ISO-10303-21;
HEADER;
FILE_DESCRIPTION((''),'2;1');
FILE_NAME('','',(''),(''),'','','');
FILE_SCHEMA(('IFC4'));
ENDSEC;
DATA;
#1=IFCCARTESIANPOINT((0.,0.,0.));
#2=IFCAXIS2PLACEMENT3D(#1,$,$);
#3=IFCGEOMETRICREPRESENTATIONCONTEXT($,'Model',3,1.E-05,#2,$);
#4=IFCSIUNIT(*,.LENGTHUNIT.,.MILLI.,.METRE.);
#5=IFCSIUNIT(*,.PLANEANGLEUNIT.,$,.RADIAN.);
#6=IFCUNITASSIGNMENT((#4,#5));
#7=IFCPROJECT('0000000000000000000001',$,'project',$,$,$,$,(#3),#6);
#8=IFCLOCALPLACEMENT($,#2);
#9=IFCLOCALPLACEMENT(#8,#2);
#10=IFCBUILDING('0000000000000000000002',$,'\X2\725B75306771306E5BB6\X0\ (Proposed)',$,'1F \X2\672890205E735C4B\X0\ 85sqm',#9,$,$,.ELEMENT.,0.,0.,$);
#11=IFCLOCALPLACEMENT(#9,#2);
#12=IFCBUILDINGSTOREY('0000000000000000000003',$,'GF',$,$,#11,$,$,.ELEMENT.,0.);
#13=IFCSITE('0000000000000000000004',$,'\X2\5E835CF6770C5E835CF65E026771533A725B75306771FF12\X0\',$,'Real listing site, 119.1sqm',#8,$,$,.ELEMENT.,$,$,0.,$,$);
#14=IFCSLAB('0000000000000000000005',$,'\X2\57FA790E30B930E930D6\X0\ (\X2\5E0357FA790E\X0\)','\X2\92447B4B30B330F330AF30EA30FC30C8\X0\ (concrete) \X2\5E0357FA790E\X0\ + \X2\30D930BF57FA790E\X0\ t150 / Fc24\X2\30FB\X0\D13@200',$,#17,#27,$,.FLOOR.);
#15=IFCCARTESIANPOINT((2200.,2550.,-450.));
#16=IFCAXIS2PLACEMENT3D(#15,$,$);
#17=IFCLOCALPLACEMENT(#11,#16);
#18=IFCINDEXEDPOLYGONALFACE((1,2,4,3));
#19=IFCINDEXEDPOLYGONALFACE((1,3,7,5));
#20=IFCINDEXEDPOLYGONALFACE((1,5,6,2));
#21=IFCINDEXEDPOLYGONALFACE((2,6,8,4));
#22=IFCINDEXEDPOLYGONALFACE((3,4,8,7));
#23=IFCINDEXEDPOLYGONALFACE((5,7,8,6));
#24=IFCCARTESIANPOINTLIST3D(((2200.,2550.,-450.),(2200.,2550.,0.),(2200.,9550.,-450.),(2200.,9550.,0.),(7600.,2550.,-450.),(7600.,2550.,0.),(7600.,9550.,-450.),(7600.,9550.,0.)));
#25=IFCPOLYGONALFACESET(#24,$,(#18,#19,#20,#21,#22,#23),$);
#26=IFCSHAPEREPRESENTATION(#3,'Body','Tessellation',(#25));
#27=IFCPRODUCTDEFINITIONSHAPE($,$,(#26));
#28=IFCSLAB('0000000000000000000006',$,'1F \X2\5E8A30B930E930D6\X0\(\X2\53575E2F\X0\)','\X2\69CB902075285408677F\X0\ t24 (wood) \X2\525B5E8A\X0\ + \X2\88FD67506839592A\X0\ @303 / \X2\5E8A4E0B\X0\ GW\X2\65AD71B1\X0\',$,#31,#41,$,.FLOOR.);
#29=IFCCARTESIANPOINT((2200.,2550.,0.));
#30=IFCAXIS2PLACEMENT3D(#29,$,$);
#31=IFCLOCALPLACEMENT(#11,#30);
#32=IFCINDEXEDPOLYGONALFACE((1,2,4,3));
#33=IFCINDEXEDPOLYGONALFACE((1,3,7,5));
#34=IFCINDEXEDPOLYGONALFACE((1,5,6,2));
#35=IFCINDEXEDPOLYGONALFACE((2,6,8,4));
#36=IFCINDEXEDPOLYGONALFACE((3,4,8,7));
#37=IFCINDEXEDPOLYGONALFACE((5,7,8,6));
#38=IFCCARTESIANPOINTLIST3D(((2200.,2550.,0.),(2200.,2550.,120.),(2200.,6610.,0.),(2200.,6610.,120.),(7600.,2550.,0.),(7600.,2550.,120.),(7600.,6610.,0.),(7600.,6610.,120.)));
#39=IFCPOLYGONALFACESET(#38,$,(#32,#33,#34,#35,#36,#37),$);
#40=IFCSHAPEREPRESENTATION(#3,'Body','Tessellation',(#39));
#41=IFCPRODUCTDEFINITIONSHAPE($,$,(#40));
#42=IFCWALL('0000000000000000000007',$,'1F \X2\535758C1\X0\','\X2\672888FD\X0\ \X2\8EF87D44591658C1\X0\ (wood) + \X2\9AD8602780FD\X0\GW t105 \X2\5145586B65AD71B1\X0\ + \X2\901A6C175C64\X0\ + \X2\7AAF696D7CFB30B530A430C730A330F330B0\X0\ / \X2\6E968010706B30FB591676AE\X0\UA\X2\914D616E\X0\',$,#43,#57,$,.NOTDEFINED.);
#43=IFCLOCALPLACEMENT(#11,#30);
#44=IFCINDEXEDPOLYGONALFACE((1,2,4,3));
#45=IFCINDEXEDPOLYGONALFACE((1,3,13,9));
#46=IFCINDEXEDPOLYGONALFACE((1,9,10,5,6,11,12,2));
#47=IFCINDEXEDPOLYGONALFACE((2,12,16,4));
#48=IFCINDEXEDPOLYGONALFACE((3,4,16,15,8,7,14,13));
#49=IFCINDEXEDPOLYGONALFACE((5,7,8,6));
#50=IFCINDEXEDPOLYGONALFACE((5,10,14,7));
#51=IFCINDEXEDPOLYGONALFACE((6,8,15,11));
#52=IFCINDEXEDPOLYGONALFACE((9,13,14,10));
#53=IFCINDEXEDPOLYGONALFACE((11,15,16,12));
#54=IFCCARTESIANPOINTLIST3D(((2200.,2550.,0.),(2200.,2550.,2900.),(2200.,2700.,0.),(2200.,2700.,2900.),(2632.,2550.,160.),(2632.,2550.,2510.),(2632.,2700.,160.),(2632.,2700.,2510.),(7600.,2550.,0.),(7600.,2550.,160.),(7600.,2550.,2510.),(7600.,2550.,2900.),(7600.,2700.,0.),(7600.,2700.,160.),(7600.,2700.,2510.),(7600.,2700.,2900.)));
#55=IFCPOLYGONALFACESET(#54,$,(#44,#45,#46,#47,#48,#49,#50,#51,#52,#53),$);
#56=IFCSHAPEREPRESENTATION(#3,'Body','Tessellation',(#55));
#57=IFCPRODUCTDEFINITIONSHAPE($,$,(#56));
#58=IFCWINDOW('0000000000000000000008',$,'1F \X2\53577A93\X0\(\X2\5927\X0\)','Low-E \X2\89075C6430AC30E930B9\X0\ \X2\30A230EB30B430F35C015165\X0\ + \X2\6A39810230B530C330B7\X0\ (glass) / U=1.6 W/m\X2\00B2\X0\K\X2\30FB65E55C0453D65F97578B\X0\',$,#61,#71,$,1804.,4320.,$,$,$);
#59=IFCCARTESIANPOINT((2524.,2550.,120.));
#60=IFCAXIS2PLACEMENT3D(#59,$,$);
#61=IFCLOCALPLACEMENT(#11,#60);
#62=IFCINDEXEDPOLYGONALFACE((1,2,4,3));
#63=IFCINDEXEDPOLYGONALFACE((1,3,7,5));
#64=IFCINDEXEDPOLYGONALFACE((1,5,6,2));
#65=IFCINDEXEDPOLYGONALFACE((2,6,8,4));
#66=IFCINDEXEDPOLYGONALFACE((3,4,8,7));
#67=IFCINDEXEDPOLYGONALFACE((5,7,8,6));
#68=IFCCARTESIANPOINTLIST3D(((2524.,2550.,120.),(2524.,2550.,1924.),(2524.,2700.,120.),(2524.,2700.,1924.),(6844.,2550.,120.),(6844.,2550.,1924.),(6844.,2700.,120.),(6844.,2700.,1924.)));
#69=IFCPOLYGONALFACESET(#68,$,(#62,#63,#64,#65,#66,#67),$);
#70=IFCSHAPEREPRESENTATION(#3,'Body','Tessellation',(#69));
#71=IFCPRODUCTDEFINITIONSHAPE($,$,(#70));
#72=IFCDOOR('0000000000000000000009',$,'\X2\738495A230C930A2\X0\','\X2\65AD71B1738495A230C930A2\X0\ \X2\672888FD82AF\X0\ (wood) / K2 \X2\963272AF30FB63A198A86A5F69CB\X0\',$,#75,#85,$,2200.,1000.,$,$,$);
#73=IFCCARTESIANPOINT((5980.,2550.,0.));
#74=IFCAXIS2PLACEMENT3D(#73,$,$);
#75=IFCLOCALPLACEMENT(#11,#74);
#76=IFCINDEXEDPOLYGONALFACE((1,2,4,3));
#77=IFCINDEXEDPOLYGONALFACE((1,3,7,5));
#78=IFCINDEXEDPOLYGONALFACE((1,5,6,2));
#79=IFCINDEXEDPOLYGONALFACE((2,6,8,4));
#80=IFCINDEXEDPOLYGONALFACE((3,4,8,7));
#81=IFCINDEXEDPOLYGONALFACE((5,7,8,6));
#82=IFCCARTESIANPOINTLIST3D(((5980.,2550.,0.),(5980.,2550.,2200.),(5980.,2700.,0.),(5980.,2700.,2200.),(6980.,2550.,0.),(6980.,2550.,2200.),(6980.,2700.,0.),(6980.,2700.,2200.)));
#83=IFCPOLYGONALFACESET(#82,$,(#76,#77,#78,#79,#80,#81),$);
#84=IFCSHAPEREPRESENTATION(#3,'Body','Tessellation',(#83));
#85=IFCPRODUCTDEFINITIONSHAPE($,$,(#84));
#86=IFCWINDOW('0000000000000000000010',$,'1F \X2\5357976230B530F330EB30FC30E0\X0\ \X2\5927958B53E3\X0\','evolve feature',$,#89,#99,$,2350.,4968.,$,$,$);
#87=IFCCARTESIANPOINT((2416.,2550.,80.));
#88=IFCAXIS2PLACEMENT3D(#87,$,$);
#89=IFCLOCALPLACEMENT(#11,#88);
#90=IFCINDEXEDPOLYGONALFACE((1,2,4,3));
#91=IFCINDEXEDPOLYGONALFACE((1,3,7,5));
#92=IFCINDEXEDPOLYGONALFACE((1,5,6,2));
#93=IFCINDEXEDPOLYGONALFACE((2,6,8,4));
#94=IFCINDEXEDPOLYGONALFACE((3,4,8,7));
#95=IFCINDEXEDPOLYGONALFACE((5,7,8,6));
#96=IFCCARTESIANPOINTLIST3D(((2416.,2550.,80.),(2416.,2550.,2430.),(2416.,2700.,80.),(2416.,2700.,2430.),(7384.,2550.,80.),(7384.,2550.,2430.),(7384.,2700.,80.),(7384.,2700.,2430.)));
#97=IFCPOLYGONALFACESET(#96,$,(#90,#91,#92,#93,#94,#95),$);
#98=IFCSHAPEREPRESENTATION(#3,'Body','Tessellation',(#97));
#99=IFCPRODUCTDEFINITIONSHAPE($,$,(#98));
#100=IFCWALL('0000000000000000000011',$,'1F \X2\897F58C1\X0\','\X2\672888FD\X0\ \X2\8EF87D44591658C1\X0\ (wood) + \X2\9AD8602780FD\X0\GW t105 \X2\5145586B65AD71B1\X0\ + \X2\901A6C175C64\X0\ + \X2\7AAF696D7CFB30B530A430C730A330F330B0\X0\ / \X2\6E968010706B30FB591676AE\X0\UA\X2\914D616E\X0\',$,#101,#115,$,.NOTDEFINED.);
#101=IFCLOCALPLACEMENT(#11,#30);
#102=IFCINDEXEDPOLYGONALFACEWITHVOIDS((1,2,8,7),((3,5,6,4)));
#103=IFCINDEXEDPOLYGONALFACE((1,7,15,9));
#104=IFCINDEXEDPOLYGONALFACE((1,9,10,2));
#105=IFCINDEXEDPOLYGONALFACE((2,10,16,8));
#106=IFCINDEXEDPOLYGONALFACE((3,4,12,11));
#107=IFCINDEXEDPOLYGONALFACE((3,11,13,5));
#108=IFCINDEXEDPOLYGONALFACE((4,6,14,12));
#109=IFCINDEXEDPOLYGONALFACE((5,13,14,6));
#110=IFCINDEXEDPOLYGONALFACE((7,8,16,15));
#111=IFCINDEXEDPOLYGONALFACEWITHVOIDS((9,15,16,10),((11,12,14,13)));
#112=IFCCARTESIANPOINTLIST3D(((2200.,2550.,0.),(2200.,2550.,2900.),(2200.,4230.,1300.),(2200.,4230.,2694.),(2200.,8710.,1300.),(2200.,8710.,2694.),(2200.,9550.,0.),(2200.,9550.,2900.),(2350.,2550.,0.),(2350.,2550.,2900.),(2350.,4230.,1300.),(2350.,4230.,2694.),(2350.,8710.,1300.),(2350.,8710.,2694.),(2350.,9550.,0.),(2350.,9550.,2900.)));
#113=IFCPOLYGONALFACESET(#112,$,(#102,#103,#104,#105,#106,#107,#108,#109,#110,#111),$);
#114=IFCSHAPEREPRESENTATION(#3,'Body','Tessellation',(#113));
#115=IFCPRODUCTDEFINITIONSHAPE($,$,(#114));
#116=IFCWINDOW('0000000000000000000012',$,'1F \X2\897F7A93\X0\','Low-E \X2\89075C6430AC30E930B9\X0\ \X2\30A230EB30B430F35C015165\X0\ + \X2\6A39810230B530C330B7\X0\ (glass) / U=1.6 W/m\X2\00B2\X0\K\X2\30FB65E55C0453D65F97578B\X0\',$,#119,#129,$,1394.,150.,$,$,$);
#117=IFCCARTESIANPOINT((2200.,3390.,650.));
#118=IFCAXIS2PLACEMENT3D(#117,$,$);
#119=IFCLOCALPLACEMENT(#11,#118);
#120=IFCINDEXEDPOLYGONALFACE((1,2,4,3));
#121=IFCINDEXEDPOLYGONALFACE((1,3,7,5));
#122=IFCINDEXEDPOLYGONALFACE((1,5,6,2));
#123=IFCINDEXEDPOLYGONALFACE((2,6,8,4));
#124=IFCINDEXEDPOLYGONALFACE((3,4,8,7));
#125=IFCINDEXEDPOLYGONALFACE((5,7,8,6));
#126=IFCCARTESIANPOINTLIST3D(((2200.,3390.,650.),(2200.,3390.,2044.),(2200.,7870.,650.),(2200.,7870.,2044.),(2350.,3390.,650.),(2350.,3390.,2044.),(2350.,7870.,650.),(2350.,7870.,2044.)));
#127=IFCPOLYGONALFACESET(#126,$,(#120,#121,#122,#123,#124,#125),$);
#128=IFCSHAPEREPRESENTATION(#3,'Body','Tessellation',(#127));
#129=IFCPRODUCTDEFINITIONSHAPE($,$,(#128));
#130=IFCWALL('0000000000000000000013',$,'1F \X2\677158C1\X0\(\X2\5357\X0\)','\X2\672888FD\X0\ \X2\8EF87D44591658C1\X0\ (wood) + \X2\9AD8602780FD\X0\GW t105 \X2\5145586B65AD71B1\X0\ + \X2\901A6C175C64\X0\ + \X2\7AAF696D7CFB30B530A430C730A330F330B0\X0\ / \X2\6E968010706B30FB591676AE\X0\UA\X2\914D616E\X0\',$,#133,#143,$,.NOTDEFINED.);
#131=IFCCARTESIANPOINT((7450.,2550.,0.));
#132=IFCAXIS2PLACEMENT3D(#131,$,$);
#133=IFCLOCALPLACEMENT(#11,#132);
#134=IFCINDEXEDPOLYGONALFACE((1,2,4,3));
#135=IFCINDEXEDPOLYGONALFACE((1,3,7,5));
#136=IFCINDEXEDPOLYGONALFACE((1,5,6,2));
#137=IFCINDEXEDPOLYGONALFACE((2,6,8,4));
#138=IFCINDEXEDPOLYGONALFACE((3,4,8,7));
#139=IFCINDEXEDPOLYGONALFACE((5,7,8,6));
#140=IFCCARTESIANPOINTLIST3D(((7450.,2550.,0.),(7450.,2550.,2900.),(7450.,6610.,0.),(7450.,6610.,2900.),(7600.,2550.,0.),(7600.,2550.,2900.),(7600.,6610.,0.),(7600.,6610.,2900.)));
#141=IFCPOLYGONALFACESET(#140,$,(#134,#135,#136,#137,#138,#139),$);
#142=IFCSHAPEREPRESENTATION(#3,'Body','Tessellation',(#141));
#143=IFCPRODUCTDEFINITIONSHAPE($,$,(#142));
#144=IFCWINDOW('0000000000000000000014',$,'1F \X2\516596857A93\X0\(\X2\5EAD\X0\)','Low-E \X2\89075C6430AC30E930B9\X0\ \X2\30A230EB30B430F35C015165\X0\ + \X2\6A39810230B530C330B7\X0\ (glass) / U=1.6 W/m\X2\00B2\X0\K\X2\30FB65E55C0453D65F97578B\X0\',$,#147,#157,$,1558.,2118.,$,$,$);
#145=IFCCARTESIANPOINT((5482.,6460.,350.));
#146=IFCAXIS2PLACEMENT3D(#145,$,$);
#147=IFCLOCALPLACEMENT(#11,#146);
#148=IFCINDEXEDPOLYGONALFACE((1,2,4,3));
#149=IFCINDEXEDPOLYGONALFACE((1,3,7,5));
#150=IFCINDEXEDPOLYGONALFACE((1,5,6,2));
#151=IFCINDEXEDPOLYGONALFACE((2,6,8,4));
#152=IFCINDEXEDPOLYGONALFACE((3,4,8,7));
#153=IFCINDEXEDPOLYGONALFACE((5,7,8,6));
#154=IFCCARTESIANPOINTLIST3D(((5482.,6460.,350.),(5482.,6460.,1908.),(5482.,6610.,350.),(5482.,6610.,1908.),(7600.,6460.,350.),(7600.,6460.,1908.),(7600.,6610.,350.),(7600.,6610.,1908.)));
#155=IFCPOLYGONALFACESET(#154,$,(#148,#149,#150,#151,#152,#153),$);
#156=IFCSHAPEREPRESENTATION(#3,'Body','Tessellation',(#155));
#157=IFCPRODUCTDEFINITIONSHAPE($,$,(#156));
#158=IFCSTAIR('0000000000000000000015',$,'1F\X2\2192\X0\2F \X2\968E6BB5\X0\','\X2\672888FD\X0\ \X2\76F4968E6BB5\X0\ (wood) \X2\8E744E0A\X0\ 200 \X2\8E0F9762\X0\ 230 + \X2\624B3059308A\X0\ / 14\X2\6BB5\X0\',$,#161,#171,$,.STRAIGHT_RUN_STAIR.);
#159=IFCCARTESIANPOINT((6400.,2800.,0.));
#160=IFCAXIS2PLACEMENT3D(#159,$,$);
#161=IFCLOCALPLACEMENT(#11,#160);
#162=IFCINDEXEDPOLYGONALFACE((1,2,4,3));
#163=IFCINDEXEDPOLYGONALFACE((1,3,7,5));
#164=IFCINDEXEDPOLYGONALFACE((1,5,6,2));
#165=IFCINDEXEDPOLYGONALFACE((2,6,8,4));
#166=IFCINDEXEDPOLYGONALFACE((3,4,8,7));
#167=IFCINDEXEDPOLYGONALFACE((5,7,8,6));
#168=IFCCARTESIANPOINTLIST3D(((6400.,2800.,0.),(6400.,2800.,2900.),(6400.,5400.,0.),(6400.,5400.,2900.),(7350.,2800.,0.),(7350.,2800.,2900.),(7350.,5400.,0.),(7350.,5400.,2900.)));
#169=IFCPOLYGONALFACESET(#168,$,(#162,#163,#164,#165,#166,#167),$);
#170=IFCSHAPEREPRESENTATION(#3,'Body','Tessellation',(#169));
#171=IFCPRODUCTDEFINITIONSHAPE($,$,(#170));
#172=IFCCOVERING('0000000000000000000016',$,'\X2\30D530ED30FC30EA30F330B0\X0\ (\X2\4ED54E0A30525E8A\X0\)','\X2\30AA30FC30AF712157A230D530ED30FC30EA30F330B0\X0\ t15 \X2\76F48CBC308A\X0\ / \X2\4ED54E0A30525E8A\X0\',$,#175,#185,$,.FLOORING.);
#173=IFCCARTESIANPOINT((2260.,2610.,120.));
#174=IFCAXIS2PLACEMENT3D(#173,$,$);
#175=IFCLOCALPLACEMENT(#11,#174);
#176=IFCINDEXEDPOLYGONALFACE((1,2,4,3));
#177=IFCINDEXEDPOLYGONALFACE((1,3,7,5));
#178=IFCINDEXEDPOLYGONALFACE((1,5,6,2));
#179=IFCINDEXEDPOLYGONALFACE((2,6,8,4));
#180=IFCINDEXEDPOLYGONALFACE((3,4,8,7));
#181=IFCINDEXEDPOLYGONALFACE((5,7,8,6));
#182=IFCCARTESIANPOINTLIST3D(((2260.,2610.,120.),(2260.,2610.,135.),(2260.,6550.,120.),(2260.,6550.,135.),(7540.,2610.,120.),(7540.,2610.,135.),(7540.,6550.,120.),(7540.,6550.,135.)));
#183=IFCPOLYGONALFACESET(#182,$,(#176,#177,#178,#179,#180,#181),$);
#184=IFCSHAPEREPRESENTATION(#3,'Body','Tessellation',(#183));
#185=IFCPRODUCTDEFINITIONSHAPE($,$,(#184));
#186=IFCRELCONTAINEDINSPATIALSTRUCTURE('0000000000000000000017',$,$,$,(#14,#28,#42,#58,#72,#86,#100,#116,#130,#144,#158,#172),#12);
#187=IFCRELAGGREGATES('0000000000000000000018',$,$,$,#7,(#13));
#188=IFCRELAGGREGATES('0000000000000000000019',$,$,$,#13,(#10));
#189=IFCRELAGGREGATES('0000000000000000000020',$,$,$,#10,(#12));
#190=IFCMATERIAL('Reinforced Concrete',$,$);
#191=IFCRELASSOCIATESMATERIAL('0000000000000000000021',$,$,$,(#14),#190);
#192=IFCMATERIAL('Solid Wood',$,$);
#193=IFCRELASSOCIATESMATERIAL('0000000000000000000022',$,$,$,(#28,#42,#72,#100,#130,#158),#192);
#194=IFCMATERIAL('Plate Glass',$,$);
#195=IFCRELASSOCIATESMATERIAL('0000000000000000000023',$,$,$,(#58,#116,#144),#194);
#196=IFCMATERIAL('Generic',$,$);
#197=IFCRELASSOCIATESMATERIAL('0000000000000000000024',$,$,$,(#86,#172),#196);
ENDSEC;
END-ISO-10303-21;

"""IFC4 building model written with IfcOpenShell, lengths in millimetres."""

from ifc_helpers import new_model, si_unit, frame, frame_2d, origin, place, context, project, spatial, rectangle, extrude, material, element, fill, save


model = new_model("IFC4")

# Units and contexts
model_context = context("Model", 3, precision=1e-05, world=origin())
ifc_project = project(units=[si_unit("LENGTHUNIT", "METRE", prefix="MILLI"), si_unit("PLANEANGLEUNIT", "RADIAN")], contexts=[model_context])

# Site, building, storey
site_placement = place(None, origin())
site = spatial("IfcSite", under=ifc_project, at=site_placement, Name="広島県広島市東区牛田東２", ObjectType="Real listing site, 119.1sqm", CompositionType="ELEMENT", RefElevation=0.0)
building_placement = place(site_placement, origin())
building = spatial("IfcBuilding", under=site, at=building_placement, Name="牛田東の家 (Proposed)", ObjectType="1F 木造平屋 85sqm", CompositionType="ELEMENT", ElevationOfRefHeight=0.0, ElevationOfTerrain=0.0)
storey_placement = place(building_placement, origin())
storey = spatial("IfcBuildingStorey", under=building, at=storey_placement, Name="GF", CompositionType="ELEMENT", Elevation=0.0)

# Slabs
ifc_material_1 = material(Name="Reinforced Concrete")
slab_1_placement = place(storey_placement, frame((2200.0, 2550.0, -450.0)))
element("IfcSlab", 1, at=slab_1_placement, inside=storey, material=ifc_material_1, Name="基礎スラブ (布基礎)", Description="鉄筋コンクリート (concrete) 布基礎 + ベタ基礎 t150 / Fc24・D13@200", PredefinedType="FLOOR", context=model_context, shape_type="SweptSolid", body=[
    extrude(rectangle(XDim=5400.0, YDim=7000.0, at=frame_2d((2700.0, 3500.0))), frame((2200.0, 2550.0, -450.0)), (0.0, 0.0, 1.0), 450.0),
])
ifc_material_2 = material(Name="Solid Wood")
slab_2_placement = place(storey_placement, frame((2200.0, 2550.0, 0.0)))
element("IfcSlab", 2, at=slab_2_placement, inside=storey, material=ifc_material_2, Name="1F 床スラブ(南帯)", Description="構造用合板 t24 (wood) 剛床 + 製材根太 @303 / 床下 GW断熱", PredefinedType="FLOOR", context=model_context, shape_type="SweptSolid", body=[
    extrude(rectangle(XDim=5400.0, YDim=4060.0, at=frame_2d((2700.0, 2030.0))), frame((2200.0, 2550.0, 0.0)), (0.0, 0.0, 1.0), 120.0),
])

# Wall, openings, windows, door
wall_1_placement = place(storey_placement, frame((2200.0, 2550.0, 0.0)))
wall_1 = element("IfcWall", 3, at=wall_1_placement, inside=storey, material=ifc_material_2, Name="1F 南壁", Description="木製 軸組外壁 (wood) + 高性能GW t105 充填断熱 + 通気層 + 窯業系サイディング / 準耐火・外皮UA配慮", PredefinedType="NOTDEFINED", context=model_context, shape_type="SweptSolid", body=[
    extrude(rectangle(XDim=5400.0, YDim=150.0, at=frame_2d((2700.0, 75.0))), frame((2200.0, 2550.0, 0.0)), (0.0, 0.0, 1.0), 2900.0),
])
opening_1_placement = place(storey_placement, frame((2524.0, 2550.0, 120.0)))
opening_1 = element("IfcOpeningElement", 4, at=opening_1_placement, cuts=wall_1, PredefinedType="NOTDEFINED", context=model_context, shape_type="SweptSolid", body=[
    extrude(rectangle(XDim=4320.0, YDim=150.0, at=frame_2d((2160.0, 75.0))), frame((2524.0, 2550.0, 120.0)), (0.0, 0.0, 1.0), 1804.0),
])
opening_2_placement = place(storey_placement, frame((5980.0, 2550.0, 0.0)))
opening_2 = element("IfcOpeningElement", 5, at=opening_2_placement, cuts=wall_1, PredefinedType="NOTDEFINED", context=model_context, shape_type="SweptSolid", body=[
    extrude(rectangle(XDim=1000.0, YDim=150.0, at=frame_2d((500.0, 75.0))), frame((5980.0, 2550.0, 0.0)), (0.0, 0.0, 1.0), 2200.0),
])
opening_3_placement = place(storey_placement, frame((2416.0, 2550.0, 80.0)))
opening_3 = element("IfcOpeningElement", 6, at=opening_3_placement, cuts=wall_1, PredefinedType="NOTDEFINED", context=model_context, shape_type="SweptSolid", body=[
    extrude(rectangle(XDim=4968.0, YDim=150.0, at=frame_2d((2484.0, 75.0))), frame((2416.0, 2550.0, 80.0)), (0.0, 0.0, 1.0), 2350.0),
])
ifc_material_3 = material(Name="Plate Glass")
window_1_placement = place(storey_placement, frame((2524.0, 2550.0, 120.0)))
window_1 = element("IfcWindow", 7, at=window_1_placement, inside=storey, material=ifc_material_3, Name="1F 南窓(大)", Description="Low-E 複層ガラス アルゴン封入 + 樹脂サッシ (glass) / U=1.6 W/m²K・日射取得型", OverallHeight=1804.0, OverallWidth=4320.0, context=model_context, shape_type="SweptSolid", body=[
    extrude(rectangle(XDim=4320.0, YDim=150.0, at=frame_2d((2160.0, 75.0))), frame((2524.0, 2550.0, 120.0)), (0.0, 0.0, 1.0), 1804.0),
])
fill(opening_1, window_1)
door_1_placement = place(storey_placement, frame((5980.0, 2550.0, 0.0)))
door_1 = element("IfcDoor", 8, at=door_1_placement, inside=storey, material=ifc_material_2, Name="玄関ドア", Description="断熱玄関ドア 木製芯 (wood) / K2 防犯・採風機構", OverallHeight=2200.0, OverallWidth=1000.0, context=model_context, shape_type="SweptSolid", body=[
    extrude(rectangle(XDim=1000.0, YDim=150.0, at=frame_2d((500.0, 75.0))), frame((5980.0, 2550.0, 0.0)), (0.0, 0.0, 1.0), 2200.0),
])
fill(opening_2, door_1)
ifc_material_4 = material(Name="Generic")
window_2_placement = place(storey_placement, frame((2416.0, 2550.0, 80.0)))
window_2 = element("IfcWindow", 9, at=window_2_placement, inside=storey, material=ifc_material_4, Name="1F 南面サンルーム 大開口", Description="evolve feature", OverallHeight=2350.0, OverallWidth=4968.0, context=model_context, shape_type="SweptSolid", body=[
    extrude(rectangle(XDim=4968.0, YDim=150.0, at=frame_2d((2484.0, 75.0))), frame((2416.0, 2550.0, 80.0)), (0.0, 0.0, 1.0), 2350.0),
])
fill(opening_3, window_2)

# Walls, openings, windows
wall_2_placement = place(storey_placement, frame((2200.0, 2550.0, 0.0)))
wall_2 = element("IfcWall", 10, at=wall_2_placement, inside=storey, material=ifc_material_2, Name="1F 西壁", Description="木製 軸組外壁 (wood) + 高性能GW t105 充填断熱 + 通気層 + 窯業系サイディング / 準耐火・外皮UA配慮", PredefinedType="NOTDEFINED", context=model_context, shape_type="SweptSolid", body=[
    extrude(rectangle(XDim=150.0, YDim=7000.0, at=frame_2d((75.0, 3500.0))), frame((2200.0, 2550.0, 0.0)), (0.0, 0.0, 1.0), 2900.0),
])
opening_4_placement = place(storey_placement, frame((2200.0, 3390.0, 650.0)))
opening_4 = element("IfcOpeningElement", 11, at=opening_4_placement, cuts=wall_2, PredefinedType="NOTDEFINED", context=model_context, shape_type="SweptSolid", body=[
    extrude(rectangle(XDim=150.0, YDim=4480.0, at=frame_2d((75.0, 2240.0))), frame((2200.0, 3390.0, 650.0)), (0.0, 0.0, 1.0), 1394.0),
])
window_3_placement = place(storey_placement, frame((2200.0, 3390.0, 650.0)))
window_3 = element("IfcWindow", 12, at=window_3_placement, inside=storey, material=ifc_material_3, Name="1F 西窓", Description="Low-E 複層ガラス アルゴン封入 + 樹脂サッシ (glass) / U=1.6 W/m²K・日射取得型", OverallHeight=1394.0, OverallWidth=150.0, context=model_context, shape_type="SweptSolid", body=[
    extrude(rectangle(XDim=150.0, YDim=4480.0, at=frame_2d((75.0, 2240.0))), frame((2200.0, 3390.0, 650.0)), (0.0, 0.0, 1.0), 1394.0),
])
fill(opening_4, window_3)
wall_3_placement = place(storey_placement, frame((7450.0, 2550.0, 0.0)))
wall_3 = element("IfcWall", 13, at=wall_3_placement, inside=storey, material=ifc_material_2, Name="1F 東壁(南)", Description="木製 軸組外壁 (wood) + 高性能GW t105 充填断熱 + 通気層 + 窯業系サイディング / 準耐火・外皮UA配慮", PredefinedType="NOTDEFINED", context=model_context, shape_type="SweptSolid", body=[
    extrude(rectangle(XDim=150.0, YDim=4060.0, at=frame_2d((75.0, 2030.0))), frame((7450.0, 2550.0, 0.0)), (0.0, 0.0, 1.0), 2900.0),
])
opening_5_placement = place(storey_placement, frame((5482.0, 6460.0, 350.0)))
opening_5 = element("IfcOpeningElement", 14, at=opening_5_placement, cuts=wall_3, PredefinedType="NOTDEFINED", context=model_context, shape_type="SweptSolid", body=[
    extrude(rectangle(XDim=2118.0, YDim=150.0, at=frame_2d((1059.0, 75.0))), frame((5482.0, 6460.0, 350.0)), (0.0, 0.0, 1.0), 1558.0),
])
window_4_placement = place(storey_placement, frame((5482.0, 6460.0, 350.0)))
window_4 = element("IfcWindow", 15, at=window_4_placement, inside=storey, material=ifc_material_3, Name="1F 入隅窓(庭)", Description="Low-E 複層ガラス アルゴン封入 + 樹脂サッシ (glass) / U=1.6 W/m²K・日射取得型", OverallHeight=1558.0, OverallWidth=2118.0, context=model_context, shape_type="SweptSolid", body=[
    extrude(rectangle(XDim=2118.0, YDim=150.0, at=frame_2d((1059.0, 75.0))), frame((5482.0, 6460.0, 350.0)), (0.0, 0.0, 1.0), 1558.0),
])
fill(opening_5, window_4)

# Stair
stair_placement = place(storey_placement, frame((6400.0, 2800.0, 0.0)))
element("IfcStair", 16, at=stair_placement, inside=storey, material=ifc_material_2, Name="1F→2F 階段", Description="木製 直階段 (wood) 蹴上 200 踏面 230 + 手すり / 14段", PredefinedType="STRAIGHT_RUN_STAIR", context=model_context, shape_type="SweptSolid", body=[
    extrude(rectangle(XDim=950.0, YDim=2600.0, at=frame_2d((475.0, 1300.0))), frame((6400.0, 2800.0, 0.0)), (0.0, 0.0, 1.0), 2900.0),
])

# Covering
covering_placement = place(storey_placement, frame((2260.0, 2610.0, 120.0)))
element("IfcCovering", 17, at=covering_placement, inside=storey, material=ifc_material_4, Name="フローリング (仕上げ床)", Description="オーク無垢フローリング t15 直貼り / 仕上げ床", PredefinedType="FLOORING", context=model_context, shape_type="SweptSolid", body=[
    extrude(rectangle(XDim=5280.0, YDim=3940.0, at=frame_2d((2640.0, 1970.0))), frame((2260.0, 2610.0, 120.0)), (0.0, 0.0, 1.0), 15.0),
])

save(model, "model.ifc")
